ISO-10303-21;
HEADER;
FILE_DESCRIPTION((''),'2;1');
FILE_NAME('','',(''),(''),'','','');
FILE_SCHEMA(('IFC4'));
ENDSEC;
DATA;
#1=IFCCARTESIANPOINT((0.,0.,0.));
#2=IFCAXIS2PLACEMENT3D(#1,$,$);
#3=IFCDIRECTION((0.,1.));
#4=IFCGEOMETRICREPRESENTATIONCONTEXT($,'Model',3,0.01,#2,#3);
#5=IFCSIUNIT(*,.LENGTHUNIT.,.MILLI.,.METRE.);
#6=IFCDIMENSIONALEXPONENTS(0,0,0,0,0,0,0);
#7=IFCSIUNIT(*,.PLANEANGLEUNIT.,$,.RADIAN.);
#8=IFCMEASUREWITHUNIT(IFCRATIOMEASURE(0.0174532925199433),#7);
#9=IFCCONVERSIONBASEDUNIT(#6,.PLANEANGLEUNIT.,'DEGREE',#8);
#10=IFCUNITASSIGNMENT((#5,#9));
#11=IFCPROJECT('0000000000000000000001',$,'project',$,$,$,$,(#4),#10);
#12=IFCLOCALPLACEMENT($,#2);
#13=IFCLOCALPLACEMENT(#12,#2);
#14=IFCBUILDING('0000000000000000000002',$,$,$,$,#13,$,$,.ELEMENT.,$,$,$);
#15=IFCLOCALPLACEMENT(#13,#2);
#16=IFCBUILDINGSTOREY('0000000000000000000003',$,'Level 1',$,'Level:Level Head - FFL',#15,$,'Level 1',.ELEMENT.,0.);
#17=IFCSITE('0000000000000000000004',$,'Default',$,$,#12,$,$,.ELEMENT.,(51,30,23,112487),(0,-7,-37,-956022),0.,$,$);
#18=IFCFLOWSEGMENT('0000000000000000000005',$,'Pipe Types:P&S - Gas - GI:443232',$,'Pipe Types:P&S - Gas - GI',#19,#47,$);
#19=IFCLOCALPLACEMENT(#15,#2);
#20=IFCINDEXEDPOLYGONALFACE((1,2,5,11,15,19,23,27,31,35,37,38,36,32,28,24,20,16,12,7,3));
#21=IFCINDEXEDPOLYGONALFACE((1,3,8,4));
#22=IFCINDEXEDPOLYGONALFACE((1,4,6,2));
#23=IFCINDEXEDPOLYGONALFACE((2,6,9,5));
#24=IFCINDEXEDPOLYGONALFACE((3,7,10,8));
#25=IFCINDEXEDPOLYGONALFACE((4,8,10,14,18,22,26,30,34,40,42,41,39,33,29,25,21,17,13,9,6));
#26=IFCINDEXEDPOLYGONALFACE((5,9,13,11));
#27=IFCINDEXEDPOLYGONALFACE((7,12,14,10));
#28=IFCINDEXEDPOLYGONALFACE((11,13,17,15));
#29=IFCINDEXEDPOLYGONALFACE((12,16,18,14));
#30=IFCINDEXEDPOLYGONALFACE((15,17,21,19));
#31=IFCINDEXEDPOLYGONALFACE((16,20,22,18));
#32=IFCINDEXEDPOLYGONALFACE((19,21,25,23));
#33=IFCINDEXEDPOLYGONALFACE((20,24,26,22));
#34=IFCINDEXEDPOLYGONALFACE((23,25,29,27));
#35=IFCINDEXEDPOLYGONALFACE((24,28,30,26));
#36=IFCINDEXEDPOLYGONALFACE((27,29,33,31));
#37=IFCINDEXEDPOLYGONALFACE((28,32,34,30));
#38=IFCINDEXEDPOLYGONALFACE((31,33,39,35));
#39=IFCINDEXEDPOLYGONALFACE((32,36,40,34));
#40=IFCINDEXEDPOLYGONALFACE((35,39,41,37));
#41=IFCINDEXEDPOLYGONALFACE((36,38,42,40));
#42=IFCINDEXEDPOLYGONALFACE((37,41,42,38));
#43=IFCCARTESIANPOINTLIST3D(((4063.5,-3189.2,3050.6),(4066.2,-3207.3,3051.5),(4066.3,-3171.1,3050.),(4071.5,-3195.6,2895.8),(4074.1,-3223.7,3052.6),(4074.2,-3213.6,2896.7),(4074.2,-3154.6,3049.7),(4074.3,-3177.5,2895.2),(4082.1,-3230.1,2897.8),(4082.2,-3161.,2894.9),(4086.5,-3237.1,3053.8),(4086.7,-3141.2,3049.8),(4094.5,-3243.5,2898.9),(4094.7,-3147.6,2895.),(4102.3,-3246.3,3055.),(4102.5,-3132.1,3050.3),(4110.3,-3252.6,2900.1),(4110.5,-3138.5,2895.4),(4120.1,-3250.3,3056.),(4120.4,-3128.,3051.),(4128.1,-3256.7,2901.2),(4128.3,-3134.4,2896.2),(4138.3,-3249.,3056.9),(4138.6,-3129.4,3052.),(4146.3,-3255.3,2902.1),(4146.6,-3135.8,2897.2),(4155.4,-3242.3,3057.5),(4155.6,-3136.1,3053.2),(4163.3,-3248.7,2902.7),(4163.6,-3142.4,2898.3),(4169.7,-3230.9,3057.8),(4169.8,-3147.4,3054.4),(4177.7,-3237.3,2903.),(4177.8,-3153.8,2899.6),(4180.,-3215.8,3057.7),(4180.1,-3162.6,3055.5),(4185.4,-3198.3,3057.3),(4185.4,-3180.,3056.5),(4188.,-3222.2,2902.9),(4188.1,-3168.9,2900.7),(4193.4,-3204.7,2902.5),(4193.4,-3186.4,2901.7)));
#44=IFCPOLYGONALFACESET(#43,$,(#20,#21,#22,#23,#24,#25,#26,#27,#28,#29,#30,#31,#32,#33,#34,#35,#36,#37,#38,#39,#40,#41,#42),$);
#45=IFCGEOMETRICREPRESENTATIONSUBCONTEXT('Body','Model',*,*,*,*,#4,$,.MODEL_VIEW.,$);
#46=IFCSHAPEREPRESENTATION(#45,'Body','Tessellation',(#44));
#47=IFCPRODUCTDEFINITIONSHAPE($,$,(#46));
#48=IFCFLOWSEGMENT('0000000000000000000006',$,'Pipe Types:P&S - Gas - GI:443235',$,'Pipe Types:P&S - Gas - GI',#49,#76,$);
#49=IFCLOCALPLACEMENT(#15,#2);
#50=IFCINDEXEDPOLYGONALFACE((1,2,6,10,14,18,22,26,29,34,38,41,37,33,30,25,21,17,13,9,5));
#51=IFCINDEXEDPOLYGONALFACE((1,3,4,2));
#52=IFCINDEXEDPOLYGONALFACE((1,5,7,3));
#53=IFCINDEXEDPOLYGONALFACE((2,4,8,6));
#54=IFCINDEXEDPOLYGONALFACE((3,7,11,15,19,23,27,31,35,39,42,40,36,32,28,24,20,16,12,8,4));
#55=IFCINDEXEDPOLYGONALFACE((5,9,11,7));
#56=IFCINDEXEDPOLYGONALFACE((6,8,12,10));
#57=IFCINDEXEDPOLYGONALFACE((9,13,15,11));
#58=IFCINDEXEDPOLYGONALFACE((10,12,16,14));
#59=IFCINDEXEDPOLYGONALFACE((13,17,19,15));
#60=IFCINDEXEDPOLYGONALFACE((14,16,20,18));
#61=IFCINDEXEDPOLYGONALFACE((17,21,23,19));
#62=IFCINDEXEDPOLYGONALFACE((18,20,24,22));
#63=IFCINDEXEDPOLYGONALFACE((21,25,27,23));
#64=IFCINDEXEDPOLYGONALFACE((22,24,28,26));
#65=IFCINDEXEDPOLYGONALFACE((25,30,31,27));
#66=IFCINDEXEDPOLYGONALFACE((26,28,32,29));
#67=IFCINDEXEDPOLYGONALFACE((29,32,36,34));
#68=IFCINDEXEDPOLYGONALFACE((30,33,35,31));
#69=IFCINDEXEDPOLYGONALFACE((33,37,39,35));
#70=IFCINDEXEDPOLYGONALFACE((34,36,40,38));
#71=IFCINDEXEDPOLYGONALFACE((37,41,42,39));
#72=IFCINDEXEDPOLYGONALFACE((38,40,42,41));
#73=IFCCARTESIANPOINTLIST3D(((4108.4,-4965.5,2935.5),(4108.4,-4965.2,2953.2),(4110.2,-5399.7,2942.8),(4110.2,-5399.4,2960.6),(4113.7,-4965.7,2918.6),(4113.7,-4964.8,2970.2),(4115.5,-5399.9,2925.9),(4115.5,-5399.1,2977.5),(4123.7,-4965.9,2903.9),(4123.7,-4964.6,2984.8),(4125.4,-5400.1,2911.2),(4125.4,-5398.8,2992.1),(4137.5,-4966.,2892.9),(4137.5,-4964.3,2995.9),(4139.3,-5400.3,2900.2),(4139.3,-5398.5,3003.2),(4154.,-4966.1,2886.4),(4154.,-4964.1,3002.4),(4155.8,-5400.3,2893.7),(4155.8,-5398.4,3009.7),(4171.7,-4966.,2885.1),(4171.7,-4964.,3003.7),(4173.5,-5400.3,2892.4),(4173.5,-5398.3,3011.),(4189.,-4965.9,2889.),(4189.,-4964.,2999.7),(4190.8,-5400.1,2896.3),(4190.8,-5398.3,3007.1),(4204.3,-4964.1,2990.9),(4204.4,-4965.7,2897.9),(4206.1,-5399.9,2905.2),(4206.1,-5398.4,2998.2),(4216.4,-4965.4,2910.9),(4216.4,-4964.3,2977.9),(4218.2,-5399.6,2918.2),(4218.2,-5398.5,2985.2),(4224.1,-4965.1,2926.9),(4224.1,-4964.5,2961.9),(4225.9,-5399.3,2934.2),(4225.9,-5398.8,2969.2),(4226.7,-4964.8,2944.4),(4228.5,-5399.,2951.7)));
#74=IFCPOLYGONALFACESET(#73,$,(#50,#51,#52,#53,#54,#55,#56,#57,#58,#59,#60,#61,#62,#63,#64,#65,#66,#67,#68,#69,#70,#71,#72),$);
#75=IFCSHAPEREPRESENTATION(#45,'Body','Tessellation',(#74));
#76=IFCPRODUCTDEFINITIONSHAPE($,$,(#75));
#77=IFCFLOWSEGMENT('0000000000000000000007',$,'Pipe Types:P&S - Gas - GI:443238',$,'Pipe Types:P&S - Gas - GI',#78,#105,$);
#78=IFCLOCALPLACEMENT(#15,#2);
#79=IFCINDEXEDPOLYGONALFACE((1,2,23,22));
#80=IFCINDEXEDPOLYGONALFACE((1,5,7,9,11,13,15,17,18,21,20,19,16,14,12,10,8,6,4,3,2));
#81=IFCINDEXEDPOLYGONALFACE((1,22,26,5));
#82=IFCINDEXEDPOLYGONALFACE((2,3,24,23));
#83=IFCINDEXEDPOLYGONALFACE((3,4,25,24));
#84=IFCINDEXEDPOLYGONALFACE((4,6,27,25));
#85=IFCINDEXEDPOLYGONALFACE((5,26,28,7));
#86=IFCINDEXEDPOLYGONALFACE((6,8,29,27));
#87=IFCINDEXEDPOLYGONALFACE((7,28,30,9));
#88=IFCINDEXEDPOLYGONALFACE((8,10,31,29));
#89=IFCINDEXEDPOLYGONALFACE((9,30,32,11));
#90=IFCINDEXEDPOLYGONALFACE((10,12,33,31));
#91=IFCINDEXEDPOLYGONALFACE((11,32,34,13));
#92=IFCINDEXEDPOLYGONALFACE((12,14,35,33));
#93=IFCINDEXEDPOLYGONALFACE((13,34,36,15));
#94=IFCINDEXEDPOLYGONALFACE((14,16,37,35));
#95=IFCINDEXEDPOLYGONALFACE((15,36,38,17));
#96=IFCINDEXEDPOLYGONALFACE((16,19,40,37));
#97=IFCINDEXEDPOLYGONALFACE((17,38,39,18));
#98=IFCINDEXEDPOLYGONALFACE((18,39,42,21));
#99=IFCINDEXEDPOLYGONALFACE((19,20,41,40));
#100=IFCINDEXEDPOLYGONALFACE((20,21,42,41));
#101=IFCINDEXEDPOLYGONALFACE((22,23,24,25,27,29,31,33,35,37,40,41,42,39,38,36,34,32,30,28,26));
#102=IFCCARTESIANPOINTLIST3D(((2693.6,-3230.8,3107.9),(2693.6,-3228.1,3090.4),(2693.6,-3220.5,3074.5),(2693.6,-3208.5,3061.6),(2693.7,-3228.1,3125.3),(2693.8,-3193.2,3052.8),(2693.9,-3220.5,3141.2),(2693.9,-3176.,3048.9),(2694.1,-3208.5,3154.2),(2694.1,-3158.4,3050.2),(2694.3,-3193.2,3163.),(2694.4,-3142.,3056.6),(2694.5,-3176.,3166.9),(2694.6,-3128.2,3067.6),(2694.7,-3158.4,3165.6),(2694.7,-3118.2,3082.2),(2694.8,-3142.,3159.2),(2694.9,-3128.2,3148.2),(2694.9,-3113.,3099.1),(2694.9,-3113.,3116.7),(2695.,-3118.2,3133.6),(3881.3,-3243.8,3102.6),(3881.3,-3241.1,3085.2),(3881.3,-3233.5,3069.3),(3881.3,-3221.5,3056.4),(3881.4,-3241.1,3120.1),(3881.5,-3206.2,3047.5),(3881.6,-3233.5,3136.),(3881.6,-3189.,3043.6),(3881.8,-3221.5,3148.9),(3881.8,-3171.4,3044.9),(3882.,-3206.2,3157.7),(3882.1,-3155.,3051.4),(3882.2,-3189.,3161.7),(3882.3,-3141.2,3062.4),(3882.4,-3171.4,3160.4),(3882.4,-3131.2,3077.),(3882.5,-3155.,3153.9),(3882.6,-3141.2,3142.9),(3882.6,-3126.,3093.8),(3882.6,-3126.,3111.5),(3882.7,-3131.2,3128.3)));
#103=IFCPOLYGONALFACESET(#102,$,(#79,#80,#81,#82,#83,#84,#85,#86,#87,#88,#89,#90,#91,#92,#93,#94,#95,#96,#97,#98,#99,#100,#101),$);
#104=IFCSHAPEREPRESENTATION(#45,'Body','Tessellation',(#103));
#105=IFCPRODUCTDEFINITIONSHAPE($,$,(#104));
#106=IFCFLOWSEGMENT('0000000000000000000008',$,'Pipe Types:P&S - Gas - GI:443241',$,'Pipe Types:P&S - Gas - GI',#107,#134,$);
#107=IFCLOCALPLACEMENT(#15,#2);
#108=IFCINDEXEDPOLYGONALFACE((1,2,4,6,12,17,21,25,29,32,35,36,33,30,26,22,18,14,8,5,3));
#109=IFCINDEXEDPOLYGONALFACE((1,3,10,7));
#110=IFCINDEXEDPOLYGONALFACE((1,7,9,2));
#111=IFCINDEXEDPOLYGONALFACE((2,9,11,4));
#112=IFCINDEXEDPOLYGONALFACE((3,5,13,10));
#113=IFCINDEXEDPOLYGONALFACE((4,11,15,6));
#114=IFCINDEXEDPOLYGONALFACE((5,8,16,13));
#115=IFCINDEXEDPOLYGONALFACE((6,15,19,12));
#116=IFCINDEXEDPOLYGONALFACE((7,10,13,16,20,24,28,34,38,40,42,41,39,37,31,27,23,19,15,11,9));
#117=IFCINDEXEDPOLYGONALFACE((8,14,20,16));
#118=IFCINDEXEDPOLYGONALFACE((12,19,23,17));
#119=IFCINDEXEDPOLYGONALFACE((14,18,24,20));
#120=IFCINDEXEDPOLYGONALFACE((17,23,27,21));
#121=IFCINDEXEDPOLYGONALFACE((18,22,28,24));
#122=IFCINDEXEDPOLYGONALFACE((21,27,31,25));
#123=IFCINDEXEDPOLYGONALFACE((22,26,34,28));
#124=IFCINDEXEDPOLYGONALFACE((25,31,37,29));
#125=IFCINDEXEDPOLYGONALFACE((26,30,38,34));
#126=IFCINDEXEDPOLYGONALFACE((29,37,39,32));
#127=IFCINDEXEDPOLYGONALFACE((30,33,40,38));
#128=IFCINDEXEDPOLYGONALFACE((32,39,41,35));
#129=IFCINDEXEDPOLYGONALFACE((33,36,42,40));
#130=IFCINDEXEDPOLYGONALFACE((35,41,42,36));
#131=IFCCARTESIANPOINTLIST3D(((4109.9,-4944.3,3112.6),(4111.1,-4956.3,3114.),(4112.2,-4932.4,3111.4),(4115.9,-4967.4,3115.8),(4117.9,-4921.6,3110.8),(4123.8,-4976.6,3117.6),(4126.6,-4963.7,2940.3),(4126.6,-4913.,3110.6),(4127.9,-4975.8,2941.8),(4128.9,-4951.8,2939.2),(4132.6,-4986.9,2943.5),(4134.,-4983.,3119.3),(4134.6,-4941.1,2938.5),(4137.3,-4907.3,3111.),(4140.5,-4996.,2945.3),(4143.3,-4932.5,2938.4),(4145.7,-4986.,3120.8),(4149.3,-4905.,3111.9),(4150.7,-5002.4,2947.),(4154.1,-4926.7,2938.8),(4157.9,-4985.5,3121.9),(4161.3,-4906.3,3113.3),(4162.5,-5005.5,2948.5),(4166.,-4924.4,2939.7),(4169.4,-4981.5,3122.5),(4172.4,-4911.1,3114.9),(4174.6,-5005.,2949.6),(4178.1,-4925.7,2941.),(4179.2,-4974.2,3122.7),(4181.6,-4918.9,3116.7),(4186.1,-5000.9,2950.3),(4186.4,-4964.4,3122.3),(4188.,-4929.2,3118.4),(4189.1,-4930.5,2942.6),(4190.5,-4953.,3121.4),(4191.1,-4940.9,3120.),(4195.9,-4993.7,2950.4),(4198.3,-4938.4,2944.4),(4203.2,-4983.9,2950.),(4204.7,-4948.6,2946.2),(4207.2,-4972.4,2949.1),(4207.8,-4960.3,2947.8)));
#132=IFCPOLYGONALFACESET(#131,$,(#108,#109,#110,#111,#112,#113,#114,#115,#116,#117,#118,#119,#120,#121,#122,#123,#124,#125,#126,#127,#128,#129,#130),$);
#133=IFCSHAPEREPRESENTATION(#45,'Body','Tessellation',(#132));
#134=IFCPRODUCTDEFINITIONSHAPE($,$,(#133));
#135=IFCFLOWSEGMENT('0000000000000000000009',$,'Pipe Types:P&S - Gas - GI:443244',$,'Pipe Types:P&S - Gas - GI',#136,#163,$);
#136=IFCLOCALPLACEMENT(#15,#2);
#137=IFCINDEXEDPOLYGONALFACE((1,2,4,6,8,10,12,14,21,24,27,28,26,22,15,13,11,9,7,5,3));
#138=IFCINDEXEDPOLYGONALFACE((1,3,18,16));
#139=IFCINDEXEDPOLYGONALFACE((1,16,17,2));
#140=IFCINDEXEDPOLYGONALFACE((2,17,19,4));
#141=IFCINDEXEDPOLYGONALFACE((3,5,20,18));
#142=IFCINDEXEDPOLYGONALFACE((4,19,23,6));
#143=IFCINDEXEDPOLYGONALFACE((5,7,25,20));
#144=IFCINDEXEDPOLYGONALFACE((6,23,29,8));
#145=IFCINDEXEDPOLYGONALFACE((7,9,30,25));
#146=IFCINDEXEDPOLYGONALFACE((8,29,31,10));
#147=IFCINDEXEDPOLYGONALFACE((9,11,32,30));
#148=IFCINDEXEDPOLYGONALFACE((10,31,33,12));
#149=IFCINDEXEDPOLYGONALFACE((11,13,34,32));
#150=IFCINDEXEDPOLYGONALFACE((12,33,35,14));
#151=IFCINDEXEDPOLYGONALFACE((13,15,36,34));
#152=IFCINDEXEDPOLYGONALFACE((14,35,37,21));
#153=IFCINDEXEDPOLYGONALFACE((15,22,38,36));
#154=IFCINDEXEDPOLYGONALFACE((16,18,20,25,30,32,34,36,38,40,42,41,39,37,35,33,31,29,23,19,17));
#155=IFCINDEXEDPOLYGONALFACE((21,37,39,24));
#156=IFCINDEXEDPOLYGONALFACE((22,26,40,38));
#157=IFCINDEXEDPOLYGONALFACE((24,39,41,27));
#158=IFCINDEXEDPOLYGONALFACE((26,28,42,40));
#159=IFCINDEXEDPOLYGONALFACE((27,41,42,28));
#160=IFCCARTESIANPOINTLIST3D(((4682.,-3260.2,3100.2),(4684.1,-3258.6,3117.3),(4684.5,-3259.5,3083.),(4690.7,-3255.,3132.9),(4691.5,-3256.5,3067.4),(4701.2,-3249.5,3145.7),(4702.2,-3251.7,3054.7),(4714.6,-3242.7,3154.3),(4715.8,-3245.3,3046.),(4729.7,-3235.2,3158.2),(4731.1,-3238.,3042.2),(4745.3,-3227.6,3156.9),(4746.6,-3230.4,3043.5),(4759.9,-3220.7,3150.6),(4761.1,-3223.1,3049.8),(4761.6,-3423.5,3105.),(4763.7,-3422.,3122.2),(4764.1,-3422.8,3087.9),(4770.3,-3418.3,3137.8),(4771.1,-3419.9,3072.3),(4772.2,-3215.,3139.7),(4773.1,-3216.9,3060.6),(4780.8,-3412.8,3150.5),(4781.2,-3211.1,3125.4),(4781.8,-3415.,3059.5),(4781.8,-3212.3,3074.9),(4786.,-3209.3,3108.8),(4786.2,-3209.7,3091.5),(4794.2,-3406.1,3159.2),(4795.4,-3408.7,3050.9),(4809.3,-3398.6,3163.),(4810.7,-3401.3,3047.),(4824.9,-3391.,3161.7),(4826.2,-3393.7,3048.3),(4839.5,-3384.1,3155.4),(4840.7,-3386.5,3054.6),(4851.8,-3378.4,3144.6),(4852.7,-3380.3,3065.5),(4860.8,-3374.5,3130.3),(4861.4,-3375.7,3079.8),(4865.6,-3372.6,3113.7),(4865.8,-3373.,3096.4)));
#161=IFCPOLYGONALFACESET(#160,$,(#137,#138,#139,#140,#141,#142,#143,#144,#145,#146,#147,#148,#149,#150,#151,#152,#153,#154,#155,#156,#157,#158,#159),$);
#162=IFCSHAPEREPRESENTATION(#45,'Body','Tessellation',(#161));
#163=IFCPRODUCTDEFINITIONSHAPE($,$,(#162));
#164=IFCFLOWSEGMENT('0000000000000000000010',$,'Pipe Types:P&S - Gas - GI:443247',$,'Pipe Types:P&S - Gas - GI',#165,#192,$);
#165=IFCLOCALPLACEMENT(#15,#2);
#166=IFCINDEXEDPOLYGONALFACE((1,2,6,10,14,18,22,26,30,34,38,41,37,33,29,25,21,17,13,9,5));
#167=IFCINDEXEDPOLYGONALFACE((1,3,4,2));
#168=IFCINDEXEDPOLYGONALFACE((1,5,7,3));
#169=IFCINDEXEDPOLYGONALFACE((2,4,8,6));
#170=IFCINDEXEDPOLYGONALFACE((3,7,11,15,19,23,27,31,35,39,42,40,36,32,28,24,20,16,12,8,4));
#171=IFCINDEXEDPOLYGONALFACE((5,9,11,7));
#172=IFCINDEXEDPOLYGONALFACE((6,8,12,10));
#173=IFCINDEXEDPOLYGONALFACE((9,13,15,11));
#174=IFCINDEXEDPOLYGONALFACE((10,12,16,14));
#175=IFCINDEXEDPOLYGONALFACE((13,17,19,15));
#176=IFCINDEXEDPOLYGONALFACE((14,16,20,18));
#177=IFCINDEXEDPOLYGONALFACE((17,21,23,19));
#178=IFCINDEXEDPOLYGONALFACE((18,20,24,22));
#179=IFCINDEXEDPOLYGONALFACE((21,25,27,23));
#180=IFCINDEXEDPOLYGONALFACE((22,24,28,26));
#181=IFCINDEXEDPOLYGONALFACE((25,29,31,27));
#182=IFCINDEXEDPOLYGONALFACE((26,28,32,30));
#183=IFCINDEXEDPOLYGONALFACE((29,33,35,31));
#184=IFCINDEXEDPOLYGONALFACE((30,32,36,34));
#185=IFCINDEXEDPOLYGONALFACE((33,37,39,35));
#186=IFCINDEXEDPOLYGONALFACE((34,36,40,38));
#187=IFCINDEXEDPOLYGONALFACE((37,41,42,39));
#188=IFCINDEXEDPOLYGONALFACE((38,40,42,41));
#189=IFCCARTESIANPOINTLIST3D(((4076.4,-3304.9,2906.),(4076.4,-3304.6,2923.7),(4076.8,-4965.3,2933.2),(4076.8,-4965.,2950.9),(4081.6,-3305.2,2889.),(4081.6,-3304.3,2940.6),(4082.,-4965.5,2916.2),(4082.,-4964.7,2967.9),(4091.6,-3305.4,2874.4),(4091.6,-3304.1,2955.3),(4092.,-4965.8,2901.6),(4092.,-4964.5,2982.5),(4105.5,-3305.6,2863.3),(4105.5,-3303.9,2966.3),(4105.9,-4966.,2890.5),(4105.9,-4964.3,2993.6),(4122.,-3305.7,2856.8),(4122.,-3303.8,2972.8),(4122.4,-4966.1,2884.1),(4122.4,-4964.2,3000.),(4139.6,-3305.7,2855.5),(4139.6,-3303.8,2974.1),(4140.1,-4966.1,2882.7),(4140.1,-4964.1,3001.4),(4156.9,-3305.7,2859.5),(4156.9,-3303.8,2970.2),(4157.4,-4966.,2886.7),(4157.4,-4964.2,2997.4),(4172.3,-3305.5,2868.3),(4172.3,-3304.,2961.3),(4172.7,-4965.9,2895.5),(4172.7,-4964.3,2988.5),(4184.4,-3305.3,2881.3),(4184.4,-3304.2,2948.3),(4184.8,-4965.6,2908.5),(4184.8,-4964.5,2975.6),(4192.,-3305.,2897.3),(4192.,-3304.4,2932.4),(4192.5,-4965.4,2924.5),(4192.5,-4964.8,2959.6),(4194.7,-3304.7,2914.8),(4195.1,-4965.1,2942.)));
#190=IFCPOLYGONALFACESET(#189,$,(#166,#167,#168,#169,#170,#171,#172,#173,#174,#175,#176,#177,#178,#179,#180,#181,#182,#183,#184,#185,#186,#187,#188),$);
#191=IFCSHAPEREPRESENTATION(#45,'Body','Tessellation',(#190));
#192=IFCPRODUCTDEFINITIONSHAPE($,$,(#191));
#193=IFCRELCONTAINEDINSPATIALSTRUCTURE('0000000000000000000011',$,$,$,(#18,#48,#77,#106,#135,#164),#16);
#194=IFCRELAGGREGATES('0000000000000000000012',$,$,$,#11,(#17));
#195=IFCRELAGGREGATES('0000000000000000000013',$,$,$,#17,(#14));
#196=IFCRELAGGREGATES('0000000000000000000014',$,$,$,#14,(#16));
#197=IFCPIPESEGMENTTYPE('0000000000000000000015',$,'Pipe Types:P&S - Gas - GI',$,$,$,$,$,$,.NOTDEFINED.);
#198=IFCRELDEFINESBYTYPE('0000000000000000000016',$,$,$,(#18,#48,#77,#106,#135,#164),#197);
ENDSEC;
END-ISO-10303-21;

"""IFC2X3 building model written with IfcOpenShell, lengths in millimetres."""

from ifc_helpers import new_model, entity, si_unit, converted_unit, direction, frame, frame_2d, origin, origin_2d_with_axis, place, context, subcontext, project, spatial, circle, extrude, type_object, element, save


model = new_model("IFC2X3")

# Units and contexts
model_context = context("Model", 3, precision=0.01, world=origin(), true_north=direction((0.0, 1.0)))
body_context = subcontext(model_context, "Body", "Model", "MODEL_VIEW")
ifc_project = project(units=[si_unit("LENGTHUNIT", "METRE", prefix="MILLI"), converted_unit("PLANEANGLEUNIT", "DEGREE", entity("IfcRatioMeasure", 0.0174532925199433), si_unit("PLANEANGLEUNIT", "RADIAN"), dimensions=[0, 0, 0, 0, 0, 0, 0])], contexts=[model_context])

# Site, building, storey
site_placement = place(None, origin())
site = spatial("IfcSite", under=ifc_project, at=site_placement, Name="Default", CompositionType="ELEMENT", RefLatitude=(51, 30, 23, 112487), RefLongitude=(0, -7, -37, -956022), RefElevation=0.0)
building_placement = place(site_placement, origin())
building = spatial("IfcBuilding", under=site, at=building_placement, CompositionType="ELEMENT")
storey_placement = place(building_placement, origin())
storey = spatial("IfcBuildingStorey", under=building, at=storey_placement, Name="Level 1", ObjectType="Level:Level Head - FFL", LongName="Level 1", CompositionType="ELEMENT", Elevation=0.0)

# Flow segments
pipe_segment_type = type_object("IfcPipeSegmentType", Name="Pipe Types:P&S - Gas - GI", PredefinedType="NOTDEFINED")
flow_segment_1_placement = place(storey_placement, origin())
element("IfcFlowSegment", 1, at=flow_segment_1_placement, inside=storey, type_object=pipe_segment_type, Name="Pipe Types:P&S - Gas - GI:443232", ObjectType="Pipe Types:P&S - Gas - GI", context=body_context, shape_type="SweptSolid", body=[
    extrude(circle(Radius=61.4, at=origin_2d_with_axis()), frame((4132.8, -3195.6, 2898.9), z_axis=(-0.051469, 0.041123, 0.997828), x_axis=(-0.624206, -0.781259, 0.0)), (0.0, 0.0, 1.0), 155.2),
])
flow_segment_2_placement = place(storey_placement, origin())
element("IfcFlowSegment", 2, at=flow_segment_2_placement, inside=storey, type_object=pipe_segment_type, Name="Pipe Types:P&S - Gas - GI:443235", ObjectType="Pipe Types:P&S - Gas - GI", context=body_context, shape_type="SweptSolid", body=[
    extrude(circle(Radius=59.5, at=frame_2d((0.0, 0.0), x_axis=(1.0, 0.0))), frame((4167.3, -4965.1, 2944.4), z_axis=(0.004107, -0.99985, 0.016822), x_axis=(0.999992, 0.004108, 0.0)), (0.0, 0.0, 1.0), 434.3),
])
flow_segment_3_placement = place(storey_placement, origin())
element("IfcFlowSegment", 3, at=flow_segment_3_placement, inside=storey, type_object=pipe_segment_type, Name="Pipe Types:P&S - Gas - GI:443238", ObjectType="Pipe Types:P&S - Gas - GI", context=body_context, shape_type="SweptSolid", body=[
    extrude(circle(Radius=59.2, at=frame_2d((0.0, 0.0), x_axis=(1.0, 0.0))), frame((3882.0, -3184.6, 3102.6), z_axis=(-0.99993, 0.010942, 0.004424), x_axis=(-0.010943, -0.99994, 0.0)), (0.0, 0.0, 1.0), 1187.8),
])
flow_segment_4_placement = place(storey_placement, origin())
element("IfcFlowSegment", 4, at=flow_segment_4_placement, inside=storey, type_object=pipe_segment_type, Name="Pipe Types:P&S - Gas - GI:443241", ObjectType="Pipe Types:P&S - Gas - GI", context=body_context, shape_type="SweptSolid", body=[
    extrude(circle(Radius=40.9, at=origin_2d_with_axis()), frame((4150.6, -4945.6, 3116.7), z_axis=(0.095925, -0.111653, -0.989107), x_axis=(0.758507, 0.651665, 0.0)), (0.0, 0.0, 1.0), 174.2),
])
flow_segment_5_placement = place(storey_placement, origin())
element("IfcFlowSegment", 5, at=flow_segment_5_placement, inside=storey, type_object=pipe_segment_type, Name="Pipe Types:P&S - Gas - GI:443244", ObjectType="Pipe Types:P&S - Gas - GI", context=body_context, shape_type="SweptSolid", body=[
    extrude(circle(Radius=58.2, at=origin_2d_with_axis()), frame((4734.3, -3234.7, 3100.2), z_axis=(0.437868, -0.898642, 0.026713), x_axis=(-0.898963, -0.438025, 0.0)), (0.0, 0.0, 1.0), 181.8),
])
flow_segment_6_placement = place(storey_placement, origin())
element("IfcFlowSegment", 6, at=flow_segment_6_placement, inside=storey, type_object=pipe_segment_type, Name="Pipe Types:P&S - Gas - GI:443247", ObjectType="Pipe Types:P&S - Gas - GI", context=body_context, shape_type="SweptSolid", body=[
    extrude(circle(Radius=59.5, at=origin_2d_with_axis()), frame((4135.2, -3304.7, 2914.8), z_axis=(0.000257, -0.999866, 0.016395), x_axis=(1.0, 0.000257, 0.0)), (0.0, 0.0, 1.0), 1660.6),
])

save(model, "model.ifc")
